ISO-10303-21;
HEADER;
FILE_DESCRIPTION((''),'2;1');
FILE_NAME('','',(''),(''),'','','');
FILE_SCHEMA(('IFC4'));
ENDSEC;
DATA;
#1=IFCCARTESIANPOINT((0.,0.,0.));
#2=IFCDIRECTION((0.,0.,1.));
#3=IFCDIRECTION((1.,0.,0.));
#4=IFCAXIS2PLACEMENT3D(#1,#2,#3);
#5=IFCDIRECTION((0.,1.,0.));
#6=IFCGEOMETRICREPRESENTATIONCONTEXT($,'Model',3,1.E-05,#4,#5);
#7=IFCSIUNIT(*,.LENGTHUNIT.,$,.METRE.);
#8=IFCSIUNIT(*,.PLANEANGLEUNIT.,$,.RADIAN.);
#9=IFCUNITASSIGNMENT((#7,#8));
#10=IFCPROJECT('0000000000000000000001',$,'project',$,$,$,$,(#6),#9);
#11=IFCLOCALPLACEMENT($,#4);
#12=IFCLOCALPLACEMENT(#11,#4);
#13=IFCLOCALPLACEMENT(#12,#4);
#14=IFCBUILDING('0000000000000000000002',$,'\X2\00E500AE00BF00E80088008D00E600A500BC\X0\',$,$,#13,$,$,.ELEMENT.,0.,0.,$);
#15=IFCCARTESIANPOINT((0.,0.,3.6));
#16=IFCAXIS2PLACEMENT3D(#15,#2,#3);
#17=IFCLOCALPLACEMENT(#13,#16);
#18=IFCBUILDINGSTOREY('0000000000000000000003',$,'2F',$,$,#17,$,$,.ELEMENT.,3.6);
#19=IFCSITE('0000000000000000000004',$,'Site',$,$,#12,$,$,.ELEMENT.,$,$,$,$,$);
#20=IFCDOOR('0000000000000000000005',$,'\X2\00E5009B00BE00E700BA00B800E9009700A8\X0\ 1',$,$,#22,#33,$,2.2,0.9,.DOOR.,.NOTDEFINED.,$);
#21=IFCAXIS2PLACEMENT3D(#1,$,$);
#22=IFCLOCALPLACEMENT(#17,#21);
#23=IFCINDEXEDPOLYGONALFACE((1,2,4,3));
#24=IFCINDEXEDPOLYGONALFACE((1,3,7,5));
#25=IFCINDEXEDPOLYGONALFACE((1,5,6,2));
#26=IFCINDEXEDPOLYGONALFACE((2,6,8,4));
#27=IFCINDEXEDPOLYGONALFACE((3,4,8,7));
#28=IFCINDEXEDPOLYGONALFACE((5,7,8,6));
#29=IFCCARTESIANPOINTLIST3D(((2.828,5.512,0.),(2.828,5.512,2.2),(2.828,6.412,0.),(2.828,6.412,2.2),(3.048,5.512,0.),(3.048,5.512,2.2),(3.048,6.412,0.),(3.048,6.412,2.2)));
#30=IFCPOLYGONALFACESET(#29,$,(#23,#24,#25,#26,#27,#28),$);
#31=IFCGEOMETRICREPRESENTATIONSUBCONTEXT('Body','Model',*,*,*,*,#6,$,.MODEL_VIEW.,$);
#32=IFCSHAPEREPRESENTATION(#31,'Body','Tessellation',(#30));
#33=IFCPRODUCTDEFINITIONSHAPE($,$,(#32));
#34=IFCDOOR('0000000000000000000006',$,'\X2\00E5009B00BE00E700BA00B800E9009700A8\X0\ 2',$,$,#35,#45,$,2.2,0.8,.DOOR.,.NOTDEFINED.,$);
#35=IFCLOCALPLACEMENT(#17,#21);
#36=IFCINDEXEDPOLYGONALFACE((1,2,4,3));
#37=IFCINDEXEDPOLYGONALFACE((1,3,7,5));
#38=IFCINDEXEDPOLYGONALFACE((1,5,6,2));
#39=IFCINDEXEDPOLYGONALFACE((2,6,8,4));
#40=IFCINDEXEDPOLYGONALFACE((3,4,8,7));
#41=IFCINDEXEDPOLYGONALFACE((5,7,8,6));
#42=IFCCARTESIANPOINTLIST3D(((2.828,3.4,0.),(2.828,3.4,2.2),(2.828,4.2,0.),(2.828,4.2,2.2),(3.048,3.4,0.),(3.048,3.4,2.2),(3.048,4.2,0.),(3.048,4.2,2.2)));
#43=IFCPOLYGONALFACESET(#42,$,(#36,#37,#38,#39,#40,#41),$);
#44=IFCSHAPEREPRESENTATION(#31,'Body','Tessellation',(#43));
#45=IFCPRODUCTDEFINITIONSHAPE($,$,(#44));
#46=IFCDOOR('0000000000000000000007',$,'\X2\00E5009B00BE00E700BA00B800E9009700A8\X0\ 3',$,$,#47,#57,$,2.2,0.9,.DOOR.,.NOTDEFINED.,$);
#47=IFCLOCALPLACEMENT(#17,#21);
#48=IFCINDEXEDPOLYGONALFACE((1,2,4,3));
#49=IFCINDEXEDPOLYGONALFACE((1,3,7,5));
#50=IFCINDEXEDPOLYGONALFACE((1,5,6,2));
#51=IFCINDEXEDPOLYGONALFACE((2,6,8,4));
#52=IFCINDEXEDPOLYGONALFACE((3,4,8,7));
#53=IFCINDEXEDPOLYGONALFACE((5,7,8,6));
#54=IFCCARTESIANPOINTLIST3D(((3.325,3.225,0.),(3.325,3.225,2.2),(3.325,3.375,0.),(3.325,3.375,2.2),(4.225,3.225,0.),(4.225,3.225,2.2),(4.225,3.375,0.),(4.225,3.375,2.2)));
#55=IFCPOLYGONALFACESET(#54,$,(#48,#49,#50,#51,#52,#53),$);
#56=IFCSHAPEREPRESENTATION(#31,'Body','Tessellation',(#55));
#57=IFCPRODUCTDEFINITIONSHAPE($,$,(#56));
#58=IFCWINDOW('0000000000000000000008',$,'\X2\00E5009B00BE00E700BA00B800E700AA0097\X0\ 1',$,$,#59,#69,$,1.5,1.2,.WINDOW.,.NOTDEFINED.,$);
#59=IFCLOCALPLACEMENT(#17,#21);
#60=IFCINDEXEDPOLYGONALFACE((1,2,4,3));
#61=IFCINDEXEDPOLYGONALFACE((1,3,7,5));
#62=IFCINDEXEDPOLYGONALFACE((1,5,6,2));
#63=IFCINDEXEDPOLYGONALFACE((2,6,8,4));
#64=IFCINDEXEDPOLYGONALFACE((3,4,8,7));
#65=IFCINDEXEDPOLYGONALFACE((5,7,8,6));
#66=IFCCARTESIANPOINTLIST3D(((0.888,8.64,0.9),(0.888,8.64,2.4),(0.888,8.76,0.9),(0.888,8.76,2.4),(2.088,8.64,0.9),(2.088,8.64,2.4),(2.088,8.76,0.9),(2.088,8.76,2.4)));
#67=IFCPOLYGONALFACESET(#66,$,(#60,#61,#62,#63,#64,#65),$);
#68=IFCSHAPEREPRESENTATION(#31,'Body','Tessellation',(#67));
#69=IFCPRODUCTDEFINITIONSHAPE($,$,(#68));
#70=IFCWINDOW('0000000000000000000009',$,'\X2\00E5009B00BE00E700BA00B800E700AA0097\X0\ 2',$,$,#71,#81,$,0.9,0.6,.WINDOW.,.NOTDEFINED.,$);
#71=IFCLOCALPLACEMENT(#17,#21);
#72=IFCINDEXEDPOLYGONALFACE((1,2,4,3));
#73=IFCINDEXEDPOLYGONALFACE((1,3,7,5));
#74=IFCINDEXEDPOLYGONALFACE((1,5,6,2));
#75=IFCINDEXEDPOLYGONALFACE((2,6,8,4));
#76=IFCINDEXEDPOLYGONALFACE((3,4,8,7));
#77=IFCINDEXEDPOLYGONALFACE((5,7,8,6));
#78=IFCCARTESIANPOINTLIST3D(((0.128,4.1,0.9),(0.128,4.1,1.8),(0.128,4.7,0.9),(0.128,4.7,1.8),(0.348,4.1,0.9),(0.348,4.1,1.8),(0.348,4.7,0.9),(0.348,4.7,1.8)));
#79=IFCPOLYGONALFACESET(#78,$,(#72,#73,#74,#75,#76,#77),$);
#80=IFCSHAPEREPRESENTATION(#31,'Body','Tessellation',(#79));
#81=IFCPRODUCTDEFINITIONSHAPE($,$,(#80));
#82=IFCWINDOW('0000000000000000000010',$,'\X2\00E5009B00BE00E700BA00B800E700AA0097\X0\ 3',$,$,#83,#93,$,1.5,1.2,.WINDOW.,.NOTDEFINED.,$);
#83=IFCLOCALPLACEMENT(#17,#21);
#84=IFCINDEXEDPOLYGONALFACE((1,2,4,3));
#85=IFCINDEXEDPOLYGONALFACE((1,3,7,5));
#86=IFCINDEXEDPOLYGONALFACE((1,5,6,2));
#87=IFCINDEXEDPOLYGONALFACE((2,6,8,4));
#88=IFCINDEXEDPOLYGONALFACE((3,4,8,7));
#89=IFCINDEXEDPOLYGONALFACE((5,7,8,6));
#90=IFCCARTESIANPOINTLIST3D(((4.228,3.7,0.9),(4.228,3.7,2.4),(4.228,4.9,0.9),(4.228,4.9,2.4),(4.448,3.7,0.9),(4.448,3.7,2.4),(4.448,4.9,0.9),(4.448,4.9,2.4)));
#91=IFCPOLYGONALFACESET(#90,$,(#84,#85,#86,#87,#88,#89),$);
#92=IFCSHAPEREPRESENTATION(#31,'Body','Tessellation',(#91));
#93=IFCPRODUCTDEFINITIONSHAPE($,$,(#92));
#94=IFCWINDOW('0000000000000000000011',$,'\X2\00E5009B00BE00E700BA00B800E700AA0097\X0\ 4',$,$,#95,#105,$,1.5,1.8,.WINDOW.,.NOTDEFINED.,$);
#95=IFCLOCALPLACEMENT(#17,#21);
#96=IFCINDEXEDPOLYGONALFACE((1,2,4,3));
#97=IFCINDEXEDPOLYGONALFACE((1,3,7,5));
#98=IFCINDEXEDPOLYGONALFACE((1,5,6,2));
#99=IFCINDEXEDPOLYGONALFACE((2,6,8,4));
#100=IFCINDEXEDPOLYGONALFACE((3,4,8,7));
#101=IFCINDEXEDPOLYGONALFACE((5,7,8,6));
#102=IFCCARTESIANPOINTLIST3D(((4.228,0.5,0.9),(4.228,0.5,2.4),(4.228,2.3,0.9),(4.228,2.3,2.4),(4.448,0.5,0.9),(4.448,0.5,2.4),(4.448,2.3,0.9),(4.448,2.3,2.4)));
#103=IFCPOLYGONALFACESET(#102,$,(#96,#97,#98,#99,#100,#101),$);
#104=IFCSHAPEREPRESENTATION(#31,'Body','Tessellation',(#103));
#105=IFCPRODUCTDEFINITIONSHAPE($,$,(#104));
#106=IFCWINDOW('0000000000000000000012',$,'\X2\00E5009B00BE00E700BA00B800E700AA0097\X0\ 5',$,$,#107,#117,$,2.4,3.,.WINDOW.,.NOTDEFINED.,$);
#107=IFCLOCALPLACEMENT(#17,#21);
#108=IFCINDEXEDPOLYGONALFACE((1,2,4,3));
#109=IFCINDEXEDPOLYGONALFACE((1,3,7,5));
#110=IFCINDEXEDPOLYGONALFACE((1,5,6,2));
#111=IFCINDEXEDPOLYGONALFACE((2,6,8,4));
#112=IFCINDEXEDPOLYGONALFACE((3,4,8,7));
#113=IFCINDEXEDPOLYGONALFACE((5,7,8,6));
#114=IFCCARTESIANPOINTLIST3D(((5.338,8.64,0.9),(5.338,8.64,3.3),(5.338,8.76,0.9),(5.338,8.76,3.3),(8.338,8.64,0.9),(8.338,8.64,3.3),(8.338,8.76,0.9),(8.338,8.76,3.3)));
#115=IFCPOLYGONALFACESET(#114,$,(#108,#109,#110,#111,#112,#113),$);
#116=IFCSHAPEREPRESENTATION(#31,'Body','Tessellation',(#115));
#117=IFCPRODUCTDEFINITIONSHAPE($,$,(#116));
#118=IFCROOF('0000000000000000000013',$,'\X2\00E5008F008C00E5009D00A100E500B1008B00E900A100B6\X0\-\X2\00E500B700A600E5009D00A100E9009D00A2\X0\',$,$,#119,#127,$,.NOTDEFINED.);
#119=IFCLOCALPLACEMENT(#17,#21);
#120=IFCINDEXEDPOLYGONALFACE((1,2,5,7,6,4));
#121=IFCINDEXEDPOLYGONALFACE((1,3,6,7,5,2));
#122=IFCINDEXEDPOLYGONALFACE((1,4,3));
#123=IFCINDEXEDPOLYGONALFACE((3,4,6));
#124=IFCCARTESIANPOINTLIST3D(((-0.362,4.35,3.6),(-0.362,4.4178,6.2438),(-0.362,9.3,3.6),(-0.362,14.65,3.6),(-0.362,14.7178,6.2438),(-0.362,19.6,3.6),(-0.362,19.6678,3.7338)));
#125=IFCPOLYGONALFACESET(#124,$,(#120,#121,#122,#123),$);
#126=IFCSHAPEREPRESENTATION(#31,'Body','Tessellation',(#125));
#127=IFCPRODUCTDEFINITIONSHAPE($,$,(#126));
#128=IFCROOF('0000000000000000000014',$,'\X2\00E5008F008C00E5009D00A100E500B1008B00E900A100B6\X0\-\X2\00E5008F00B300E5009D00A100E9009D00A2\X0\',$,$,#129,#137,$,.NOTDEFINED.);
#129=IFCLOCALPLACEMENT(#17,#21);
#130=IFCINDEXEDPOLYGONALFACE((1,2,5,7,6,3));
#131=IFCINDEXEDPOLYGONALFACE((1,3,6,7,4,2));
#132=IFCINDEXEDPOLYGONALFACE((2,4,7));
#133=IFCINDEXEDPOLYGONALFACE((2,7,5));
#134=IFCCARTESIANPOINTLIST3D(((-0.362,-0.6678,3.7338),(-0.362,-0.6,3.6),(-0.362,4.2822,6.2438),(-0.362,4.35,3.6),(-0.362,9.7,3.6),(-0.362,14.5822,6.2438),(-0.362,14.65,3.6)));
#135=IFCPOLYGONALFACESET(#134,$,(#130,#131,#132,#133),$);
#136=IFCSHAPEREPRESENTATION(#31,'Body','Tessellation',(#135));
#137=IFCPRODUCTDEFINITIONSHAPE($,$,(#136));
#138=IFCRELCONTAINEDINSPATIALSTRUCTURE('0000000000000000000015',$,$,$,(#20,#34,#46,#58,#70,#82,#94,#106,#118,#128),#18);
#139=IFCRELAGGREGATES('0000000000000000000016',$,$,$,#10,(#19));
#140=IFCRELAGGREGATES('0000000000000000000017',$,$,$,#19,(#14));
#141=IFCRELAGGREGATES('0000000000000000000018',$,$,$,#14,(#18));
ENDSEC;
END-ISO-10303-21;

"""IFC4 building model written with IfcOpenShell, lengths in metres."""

from ifc_helpers import new_model, si_unit, direction, frame, frame_2d, origin_with_axes, place, context, subcontext, project, spatial, polyline, rectangle, outline, extrude, element, save


model = new_model("IFC4")

# Units and contexts
model_context = context("Model", 3, precision=1e-05, world=origin_with_axes(), true_north=direction((0.0, 1.0, 0.0)))
body_context = subcontext(model_context, "Body", "Model", "MODEL_VIEW")
ifc_project = project(units=[si_unit("LENGTHUNIT", "METRE"), si_unit("PLANEANGLEUNIT", "RADIAN")], contexts=[model_context])

# Site, building, storey
placement = place(None, origin_with_axes())
site_placement = place(placement, origin_with_axes())
site = spatial("IfcSite", under=ifc_project, at=site_placement, Name="Site", CompositionType="ELEMENT")
building_placement = place(site_placement, origin_with_axes())
building = spatial("IfcBuilding", under=site, at=building_placement, Name="å®¿è\u0088\u008dæ¥¼", CompositionType="ELEMENT", ElevationOfRefHeight=0.0, ElevationOfTerrain=0.0)
storey_placement = place(building_placement, frame((0.0, 0.0, 3.6), z_axis=(0.0, 0.0, 1.0), x_axis=(1.0, 0.0, 0.0)))
storey = spatial("IfcBuildingStorey", under=building, at=storey_placement, Name="2F", CompositionType="ELEMENT", Elevation=3.6)

# Doors
door_1_placement = place(storey_placement, frame((2.938, 5.962, 0.0), z_axis=(0.0, 0.0, 1.0), x_axis=(0.0, 1.0, 0.0)))
element("IfcDoor", 1, at=door_1_placement, inside=storey, Name="å\u009b¾çº¸é\u0097¨ 1", OperationType="NOTDEFINED", OverallHeight=2.2, OverallWidth=0.9, PredefinedType="DOOR", context=body_context, shape_type="SweptSolid", body=[
    extrude(rectangle(XDim=0.9, YDim=0.22, at=frame_2d((0.0, 0.0), x_axis=(1.0, 0.0, 0.0))), frame((0.0, 0.0, 0.0), z_axis=(0.0, 0.0, 1.0)), (0.0, 0.0, 1.0), 2.2),
])
door_2_placement = place(storey_placement, frame((2.938, 3.8, 0.0), z_axis=(0.0, 0.0, 1.0), x_axis=(0.0, 1.0, 0.0)))
element("IfcDoor", 2, at=door_2_placement, inside=storey, Name="å\u009b¾çº¸é\u0097¨ 2", OperationType="NOTDEFINED", OverallHeight=2.2, OverallWidth=0.8, PredefinedType="DOOR", context=body_context, shape_type="SweptSolid", body=[
    extrude(rectangle(XDim=0.8, YDim=0.22, at=frame_2d((0.0, 0.0), x_axis=(1.0, 0.0, 0.0))), frame((0.0, 0.0, 0.0), z_axis=(0.0, 0.0, 1.0)), (0.0, 0.0, 1.0), 2.2),
])
door_3_placement = place(storey_placement, frame((3.775, 3.3, 0.0), z_axis=(0.0, 0.0, 1.0), x_axis=(1.0, 0.0, 0.0)))
element("IfcDoor", 3, at=door_3_placement, inside=storey, Name="å\u009b¾çº¸é\u0097¨ 3", OperationType="NOTDEFINED", OverallHeight=2.2, OverallWidth=0.9, PredefinedType="DOOR", context=body_context, shape_type="SweptSolid", body=[
    extrude(rectangle(XDim=0.9, YDim=0.15, at=frame_2d((0.0, 0.0), x_axis=(1.0, 0.0, 0.0))), frame((0.0, 0.0, 0.0), z_axis=(0.0, 0.0, 1.0)), (0.0, 0.0, 1.0), 2.2),
])

# Windows
window_1_placement = place(storey_placement, frame((1.488, 8.7, 0.9), z_axis=(0.0, 0.0, 1.0), x_axis=(1.0, 0.0, 0.0)))
element("IfcWindow", 4, at=window_1_placement, inside=storey, Name="å\u009b¾çº¸çª\u0097 1", OverallHeight=1.5, OverallWidth=1.2, PartitioningType="NOTDEFINED", PredefinedType="WINDOW", context=body_context, shape_type="SweptSolid", body=[
    extrude(rectangle(XDim=1.2, YDim=0.12, at=frame_2d((0.0, 0.0), x_axis=(1.0, 0.0, 0.0))), frame((0.0, 0.0, 0.0), z_axis=(0.0, 0.0, 1.0)), (0.0, 0.0, 1.0), 1.5),
])
window_2_placement = place(storey_placement, frame((0.238, 4.4, 0.9), z_axis=(0.0, 0.0, 1.0), x_axis=(0.0, 1.0, 0.0)))
element("IfcWindow", 5, at=window_2_placement, inside=storey, Name="å\u009b¾çº¸çª\u0097 2", OverallHeight=0.9, OverallWidth=0.6, PartitioningType="NOTDEFINED", PredefinedType="WINDOW", context=body_context, shape_type="SweptSolid", body=[
    extrude(rectangle(XDim=0.6, YDim=0.22, at=frame_2d((0.0, 0.0), x_axis=(1.0, 0.0, 0.0))), frame((0.0, 0.0, 0.0), z_axis=(0.0, 0.0, 1.0)), (0.0, 0.0, 1.0), 0.9),
])
window_3_placement = place(storey_placement, frame((4.338, 4.3, 0.9), z_axis=(0.0, 0.0, 1.0), x_axis=(0.0, 1.0, 0.0)))
element("IfcWindow", 6, at=window_3_placement, inside=storey, Name="å\u009b¾çº¸çª\u0097 3", OverallHeight=1.5, OverallWidth=1.2, PartitioningType="NOTDEFINED", PredefinedType="WINDOW", context=body_context, shape_type="SweptSolid", body=[
    extrude(rectangle(XDim=1.2, YDim=0.22, at=frame_2d((0.0, 0.0), x_axis=(1.0, 0.0, 0.0))), frame((0.0, 0.0, 0.0), z_axis=(0.0, 0.0, 1.0)), (0.0, 0.0, 1.0), 1.5),
])
window_4_placement = place(storey_placement, frame((4.338, 1.4, 0.9), z_axis=(0.0, 0.0, 1.0), x_axis=(0.0, 1.0, 0.0)))
element("IfcWindow", 7, at=window_4_placement, inside=storey, Name="å\u009b¾çº¸çª\u0097 4", OverallHeight=1.5, OverallWidth=1.8, PartitioningType="NOTDEFINED", PredefinedType="WINDOW", context=body_context, shape_type="SweptSolid", body=[
    extrude(rectangle(XDim=1.8, YDim=0.22, at=frame_2d((0.0, 0.0), x_axis=(1.0, 0.0, 0.0))), frame((0.0, 0.0, 0.0), z_axis=(0.0, 0.0, 1.0)), (0.0, 0.0, 1.0), 1.5),
])
window_5_placement = place(storey_placement, frame((6.838, 8.7, 0.9), z_axis=(0.0, 0.0, 1.0), x_axis=(-1.0, 0.0, 0.0)))
element("IfcWindow", 8, at=window_5_placement, inside=storey, Name="å\u009b¾çº¸çª\u0097 5", OverallHeight=2.4, OverallWidth=3.0, PartitioningType="NOTDEFINED", PredefinedType="WINDOW", context=body_context, shape_type="SweptSolid", body=[
    extrude(rectangle(XDim=3.0, YDim=0.12, at=frame_2d((0.0, 0.0), x_axis=(1.0, 0.0, 0.0))), frame((0.0, 0.0, 0.0), z_axis=(0.0, 0.0, 1.0)), (0.0, 0.0, 1.0), 2.4),
])

# Roofs
roof_1_placement = place(storey_placement, frame((4.788, 4.35, 3.6), z_axis=(0.0, 0.0, 1.0), x_axis=(1.0, 0.0, 0.0)))
element("IfcRoof", 9, at=roof_1_placement, inside=storey, Name="å\u008f\u008cå\u009d¡å±\u008bé¡¶-å·¦å\u009d¡é\u009d¢", PredefinedType="NOTDEFINED", context=body_context, shape_type="SweptSolid", body=[
    extrude(outline(polyline([(0.0, 0.0), (4.95, 0.0), (5.0178, 0.1338), (0.0678, 2.6438), (0.0, 0.0)])), frame((-5.15, 0.0, 0.0), z_axis=(1.0, 0.0, 0.0), x_axis=(0.0, 1.0, 0.0)), (1.0, 0.0, 0.0), 10.3),
])
roof_2_placement = place(storey_placement, frame((4.788, 4.35, 3.6), z_axis=(0.0, 0.0, 1.0), x_axis=(1.0, 0.0, 0.0)))
element("IfcRoof", 10, at=roof_2_placement, inside=storey, Name="å\u008f\u008cå\u009d¡å±\u008bé¡¶-å\u008f³å\u009d¡é\u009d¢", PredefinedType="NOTDEFINED", context=body_context, shape_type="SweptSolid", body=[
    extrude(outline(polyline([(0.0, 0.0), (-4.95, 0.0), (-5.0178, 0.1338), (-0.0678, 2.6438), (0.0, 0.0)])), frame((-5.15, 0.0, 0.0), z_axis=(1.0, 0.0, 0.0), x_axis=(0.0, 1.0, 0.0)), (1.0, 0.0, 0.0), 10.3),
])

save(model, "model.ifc")
